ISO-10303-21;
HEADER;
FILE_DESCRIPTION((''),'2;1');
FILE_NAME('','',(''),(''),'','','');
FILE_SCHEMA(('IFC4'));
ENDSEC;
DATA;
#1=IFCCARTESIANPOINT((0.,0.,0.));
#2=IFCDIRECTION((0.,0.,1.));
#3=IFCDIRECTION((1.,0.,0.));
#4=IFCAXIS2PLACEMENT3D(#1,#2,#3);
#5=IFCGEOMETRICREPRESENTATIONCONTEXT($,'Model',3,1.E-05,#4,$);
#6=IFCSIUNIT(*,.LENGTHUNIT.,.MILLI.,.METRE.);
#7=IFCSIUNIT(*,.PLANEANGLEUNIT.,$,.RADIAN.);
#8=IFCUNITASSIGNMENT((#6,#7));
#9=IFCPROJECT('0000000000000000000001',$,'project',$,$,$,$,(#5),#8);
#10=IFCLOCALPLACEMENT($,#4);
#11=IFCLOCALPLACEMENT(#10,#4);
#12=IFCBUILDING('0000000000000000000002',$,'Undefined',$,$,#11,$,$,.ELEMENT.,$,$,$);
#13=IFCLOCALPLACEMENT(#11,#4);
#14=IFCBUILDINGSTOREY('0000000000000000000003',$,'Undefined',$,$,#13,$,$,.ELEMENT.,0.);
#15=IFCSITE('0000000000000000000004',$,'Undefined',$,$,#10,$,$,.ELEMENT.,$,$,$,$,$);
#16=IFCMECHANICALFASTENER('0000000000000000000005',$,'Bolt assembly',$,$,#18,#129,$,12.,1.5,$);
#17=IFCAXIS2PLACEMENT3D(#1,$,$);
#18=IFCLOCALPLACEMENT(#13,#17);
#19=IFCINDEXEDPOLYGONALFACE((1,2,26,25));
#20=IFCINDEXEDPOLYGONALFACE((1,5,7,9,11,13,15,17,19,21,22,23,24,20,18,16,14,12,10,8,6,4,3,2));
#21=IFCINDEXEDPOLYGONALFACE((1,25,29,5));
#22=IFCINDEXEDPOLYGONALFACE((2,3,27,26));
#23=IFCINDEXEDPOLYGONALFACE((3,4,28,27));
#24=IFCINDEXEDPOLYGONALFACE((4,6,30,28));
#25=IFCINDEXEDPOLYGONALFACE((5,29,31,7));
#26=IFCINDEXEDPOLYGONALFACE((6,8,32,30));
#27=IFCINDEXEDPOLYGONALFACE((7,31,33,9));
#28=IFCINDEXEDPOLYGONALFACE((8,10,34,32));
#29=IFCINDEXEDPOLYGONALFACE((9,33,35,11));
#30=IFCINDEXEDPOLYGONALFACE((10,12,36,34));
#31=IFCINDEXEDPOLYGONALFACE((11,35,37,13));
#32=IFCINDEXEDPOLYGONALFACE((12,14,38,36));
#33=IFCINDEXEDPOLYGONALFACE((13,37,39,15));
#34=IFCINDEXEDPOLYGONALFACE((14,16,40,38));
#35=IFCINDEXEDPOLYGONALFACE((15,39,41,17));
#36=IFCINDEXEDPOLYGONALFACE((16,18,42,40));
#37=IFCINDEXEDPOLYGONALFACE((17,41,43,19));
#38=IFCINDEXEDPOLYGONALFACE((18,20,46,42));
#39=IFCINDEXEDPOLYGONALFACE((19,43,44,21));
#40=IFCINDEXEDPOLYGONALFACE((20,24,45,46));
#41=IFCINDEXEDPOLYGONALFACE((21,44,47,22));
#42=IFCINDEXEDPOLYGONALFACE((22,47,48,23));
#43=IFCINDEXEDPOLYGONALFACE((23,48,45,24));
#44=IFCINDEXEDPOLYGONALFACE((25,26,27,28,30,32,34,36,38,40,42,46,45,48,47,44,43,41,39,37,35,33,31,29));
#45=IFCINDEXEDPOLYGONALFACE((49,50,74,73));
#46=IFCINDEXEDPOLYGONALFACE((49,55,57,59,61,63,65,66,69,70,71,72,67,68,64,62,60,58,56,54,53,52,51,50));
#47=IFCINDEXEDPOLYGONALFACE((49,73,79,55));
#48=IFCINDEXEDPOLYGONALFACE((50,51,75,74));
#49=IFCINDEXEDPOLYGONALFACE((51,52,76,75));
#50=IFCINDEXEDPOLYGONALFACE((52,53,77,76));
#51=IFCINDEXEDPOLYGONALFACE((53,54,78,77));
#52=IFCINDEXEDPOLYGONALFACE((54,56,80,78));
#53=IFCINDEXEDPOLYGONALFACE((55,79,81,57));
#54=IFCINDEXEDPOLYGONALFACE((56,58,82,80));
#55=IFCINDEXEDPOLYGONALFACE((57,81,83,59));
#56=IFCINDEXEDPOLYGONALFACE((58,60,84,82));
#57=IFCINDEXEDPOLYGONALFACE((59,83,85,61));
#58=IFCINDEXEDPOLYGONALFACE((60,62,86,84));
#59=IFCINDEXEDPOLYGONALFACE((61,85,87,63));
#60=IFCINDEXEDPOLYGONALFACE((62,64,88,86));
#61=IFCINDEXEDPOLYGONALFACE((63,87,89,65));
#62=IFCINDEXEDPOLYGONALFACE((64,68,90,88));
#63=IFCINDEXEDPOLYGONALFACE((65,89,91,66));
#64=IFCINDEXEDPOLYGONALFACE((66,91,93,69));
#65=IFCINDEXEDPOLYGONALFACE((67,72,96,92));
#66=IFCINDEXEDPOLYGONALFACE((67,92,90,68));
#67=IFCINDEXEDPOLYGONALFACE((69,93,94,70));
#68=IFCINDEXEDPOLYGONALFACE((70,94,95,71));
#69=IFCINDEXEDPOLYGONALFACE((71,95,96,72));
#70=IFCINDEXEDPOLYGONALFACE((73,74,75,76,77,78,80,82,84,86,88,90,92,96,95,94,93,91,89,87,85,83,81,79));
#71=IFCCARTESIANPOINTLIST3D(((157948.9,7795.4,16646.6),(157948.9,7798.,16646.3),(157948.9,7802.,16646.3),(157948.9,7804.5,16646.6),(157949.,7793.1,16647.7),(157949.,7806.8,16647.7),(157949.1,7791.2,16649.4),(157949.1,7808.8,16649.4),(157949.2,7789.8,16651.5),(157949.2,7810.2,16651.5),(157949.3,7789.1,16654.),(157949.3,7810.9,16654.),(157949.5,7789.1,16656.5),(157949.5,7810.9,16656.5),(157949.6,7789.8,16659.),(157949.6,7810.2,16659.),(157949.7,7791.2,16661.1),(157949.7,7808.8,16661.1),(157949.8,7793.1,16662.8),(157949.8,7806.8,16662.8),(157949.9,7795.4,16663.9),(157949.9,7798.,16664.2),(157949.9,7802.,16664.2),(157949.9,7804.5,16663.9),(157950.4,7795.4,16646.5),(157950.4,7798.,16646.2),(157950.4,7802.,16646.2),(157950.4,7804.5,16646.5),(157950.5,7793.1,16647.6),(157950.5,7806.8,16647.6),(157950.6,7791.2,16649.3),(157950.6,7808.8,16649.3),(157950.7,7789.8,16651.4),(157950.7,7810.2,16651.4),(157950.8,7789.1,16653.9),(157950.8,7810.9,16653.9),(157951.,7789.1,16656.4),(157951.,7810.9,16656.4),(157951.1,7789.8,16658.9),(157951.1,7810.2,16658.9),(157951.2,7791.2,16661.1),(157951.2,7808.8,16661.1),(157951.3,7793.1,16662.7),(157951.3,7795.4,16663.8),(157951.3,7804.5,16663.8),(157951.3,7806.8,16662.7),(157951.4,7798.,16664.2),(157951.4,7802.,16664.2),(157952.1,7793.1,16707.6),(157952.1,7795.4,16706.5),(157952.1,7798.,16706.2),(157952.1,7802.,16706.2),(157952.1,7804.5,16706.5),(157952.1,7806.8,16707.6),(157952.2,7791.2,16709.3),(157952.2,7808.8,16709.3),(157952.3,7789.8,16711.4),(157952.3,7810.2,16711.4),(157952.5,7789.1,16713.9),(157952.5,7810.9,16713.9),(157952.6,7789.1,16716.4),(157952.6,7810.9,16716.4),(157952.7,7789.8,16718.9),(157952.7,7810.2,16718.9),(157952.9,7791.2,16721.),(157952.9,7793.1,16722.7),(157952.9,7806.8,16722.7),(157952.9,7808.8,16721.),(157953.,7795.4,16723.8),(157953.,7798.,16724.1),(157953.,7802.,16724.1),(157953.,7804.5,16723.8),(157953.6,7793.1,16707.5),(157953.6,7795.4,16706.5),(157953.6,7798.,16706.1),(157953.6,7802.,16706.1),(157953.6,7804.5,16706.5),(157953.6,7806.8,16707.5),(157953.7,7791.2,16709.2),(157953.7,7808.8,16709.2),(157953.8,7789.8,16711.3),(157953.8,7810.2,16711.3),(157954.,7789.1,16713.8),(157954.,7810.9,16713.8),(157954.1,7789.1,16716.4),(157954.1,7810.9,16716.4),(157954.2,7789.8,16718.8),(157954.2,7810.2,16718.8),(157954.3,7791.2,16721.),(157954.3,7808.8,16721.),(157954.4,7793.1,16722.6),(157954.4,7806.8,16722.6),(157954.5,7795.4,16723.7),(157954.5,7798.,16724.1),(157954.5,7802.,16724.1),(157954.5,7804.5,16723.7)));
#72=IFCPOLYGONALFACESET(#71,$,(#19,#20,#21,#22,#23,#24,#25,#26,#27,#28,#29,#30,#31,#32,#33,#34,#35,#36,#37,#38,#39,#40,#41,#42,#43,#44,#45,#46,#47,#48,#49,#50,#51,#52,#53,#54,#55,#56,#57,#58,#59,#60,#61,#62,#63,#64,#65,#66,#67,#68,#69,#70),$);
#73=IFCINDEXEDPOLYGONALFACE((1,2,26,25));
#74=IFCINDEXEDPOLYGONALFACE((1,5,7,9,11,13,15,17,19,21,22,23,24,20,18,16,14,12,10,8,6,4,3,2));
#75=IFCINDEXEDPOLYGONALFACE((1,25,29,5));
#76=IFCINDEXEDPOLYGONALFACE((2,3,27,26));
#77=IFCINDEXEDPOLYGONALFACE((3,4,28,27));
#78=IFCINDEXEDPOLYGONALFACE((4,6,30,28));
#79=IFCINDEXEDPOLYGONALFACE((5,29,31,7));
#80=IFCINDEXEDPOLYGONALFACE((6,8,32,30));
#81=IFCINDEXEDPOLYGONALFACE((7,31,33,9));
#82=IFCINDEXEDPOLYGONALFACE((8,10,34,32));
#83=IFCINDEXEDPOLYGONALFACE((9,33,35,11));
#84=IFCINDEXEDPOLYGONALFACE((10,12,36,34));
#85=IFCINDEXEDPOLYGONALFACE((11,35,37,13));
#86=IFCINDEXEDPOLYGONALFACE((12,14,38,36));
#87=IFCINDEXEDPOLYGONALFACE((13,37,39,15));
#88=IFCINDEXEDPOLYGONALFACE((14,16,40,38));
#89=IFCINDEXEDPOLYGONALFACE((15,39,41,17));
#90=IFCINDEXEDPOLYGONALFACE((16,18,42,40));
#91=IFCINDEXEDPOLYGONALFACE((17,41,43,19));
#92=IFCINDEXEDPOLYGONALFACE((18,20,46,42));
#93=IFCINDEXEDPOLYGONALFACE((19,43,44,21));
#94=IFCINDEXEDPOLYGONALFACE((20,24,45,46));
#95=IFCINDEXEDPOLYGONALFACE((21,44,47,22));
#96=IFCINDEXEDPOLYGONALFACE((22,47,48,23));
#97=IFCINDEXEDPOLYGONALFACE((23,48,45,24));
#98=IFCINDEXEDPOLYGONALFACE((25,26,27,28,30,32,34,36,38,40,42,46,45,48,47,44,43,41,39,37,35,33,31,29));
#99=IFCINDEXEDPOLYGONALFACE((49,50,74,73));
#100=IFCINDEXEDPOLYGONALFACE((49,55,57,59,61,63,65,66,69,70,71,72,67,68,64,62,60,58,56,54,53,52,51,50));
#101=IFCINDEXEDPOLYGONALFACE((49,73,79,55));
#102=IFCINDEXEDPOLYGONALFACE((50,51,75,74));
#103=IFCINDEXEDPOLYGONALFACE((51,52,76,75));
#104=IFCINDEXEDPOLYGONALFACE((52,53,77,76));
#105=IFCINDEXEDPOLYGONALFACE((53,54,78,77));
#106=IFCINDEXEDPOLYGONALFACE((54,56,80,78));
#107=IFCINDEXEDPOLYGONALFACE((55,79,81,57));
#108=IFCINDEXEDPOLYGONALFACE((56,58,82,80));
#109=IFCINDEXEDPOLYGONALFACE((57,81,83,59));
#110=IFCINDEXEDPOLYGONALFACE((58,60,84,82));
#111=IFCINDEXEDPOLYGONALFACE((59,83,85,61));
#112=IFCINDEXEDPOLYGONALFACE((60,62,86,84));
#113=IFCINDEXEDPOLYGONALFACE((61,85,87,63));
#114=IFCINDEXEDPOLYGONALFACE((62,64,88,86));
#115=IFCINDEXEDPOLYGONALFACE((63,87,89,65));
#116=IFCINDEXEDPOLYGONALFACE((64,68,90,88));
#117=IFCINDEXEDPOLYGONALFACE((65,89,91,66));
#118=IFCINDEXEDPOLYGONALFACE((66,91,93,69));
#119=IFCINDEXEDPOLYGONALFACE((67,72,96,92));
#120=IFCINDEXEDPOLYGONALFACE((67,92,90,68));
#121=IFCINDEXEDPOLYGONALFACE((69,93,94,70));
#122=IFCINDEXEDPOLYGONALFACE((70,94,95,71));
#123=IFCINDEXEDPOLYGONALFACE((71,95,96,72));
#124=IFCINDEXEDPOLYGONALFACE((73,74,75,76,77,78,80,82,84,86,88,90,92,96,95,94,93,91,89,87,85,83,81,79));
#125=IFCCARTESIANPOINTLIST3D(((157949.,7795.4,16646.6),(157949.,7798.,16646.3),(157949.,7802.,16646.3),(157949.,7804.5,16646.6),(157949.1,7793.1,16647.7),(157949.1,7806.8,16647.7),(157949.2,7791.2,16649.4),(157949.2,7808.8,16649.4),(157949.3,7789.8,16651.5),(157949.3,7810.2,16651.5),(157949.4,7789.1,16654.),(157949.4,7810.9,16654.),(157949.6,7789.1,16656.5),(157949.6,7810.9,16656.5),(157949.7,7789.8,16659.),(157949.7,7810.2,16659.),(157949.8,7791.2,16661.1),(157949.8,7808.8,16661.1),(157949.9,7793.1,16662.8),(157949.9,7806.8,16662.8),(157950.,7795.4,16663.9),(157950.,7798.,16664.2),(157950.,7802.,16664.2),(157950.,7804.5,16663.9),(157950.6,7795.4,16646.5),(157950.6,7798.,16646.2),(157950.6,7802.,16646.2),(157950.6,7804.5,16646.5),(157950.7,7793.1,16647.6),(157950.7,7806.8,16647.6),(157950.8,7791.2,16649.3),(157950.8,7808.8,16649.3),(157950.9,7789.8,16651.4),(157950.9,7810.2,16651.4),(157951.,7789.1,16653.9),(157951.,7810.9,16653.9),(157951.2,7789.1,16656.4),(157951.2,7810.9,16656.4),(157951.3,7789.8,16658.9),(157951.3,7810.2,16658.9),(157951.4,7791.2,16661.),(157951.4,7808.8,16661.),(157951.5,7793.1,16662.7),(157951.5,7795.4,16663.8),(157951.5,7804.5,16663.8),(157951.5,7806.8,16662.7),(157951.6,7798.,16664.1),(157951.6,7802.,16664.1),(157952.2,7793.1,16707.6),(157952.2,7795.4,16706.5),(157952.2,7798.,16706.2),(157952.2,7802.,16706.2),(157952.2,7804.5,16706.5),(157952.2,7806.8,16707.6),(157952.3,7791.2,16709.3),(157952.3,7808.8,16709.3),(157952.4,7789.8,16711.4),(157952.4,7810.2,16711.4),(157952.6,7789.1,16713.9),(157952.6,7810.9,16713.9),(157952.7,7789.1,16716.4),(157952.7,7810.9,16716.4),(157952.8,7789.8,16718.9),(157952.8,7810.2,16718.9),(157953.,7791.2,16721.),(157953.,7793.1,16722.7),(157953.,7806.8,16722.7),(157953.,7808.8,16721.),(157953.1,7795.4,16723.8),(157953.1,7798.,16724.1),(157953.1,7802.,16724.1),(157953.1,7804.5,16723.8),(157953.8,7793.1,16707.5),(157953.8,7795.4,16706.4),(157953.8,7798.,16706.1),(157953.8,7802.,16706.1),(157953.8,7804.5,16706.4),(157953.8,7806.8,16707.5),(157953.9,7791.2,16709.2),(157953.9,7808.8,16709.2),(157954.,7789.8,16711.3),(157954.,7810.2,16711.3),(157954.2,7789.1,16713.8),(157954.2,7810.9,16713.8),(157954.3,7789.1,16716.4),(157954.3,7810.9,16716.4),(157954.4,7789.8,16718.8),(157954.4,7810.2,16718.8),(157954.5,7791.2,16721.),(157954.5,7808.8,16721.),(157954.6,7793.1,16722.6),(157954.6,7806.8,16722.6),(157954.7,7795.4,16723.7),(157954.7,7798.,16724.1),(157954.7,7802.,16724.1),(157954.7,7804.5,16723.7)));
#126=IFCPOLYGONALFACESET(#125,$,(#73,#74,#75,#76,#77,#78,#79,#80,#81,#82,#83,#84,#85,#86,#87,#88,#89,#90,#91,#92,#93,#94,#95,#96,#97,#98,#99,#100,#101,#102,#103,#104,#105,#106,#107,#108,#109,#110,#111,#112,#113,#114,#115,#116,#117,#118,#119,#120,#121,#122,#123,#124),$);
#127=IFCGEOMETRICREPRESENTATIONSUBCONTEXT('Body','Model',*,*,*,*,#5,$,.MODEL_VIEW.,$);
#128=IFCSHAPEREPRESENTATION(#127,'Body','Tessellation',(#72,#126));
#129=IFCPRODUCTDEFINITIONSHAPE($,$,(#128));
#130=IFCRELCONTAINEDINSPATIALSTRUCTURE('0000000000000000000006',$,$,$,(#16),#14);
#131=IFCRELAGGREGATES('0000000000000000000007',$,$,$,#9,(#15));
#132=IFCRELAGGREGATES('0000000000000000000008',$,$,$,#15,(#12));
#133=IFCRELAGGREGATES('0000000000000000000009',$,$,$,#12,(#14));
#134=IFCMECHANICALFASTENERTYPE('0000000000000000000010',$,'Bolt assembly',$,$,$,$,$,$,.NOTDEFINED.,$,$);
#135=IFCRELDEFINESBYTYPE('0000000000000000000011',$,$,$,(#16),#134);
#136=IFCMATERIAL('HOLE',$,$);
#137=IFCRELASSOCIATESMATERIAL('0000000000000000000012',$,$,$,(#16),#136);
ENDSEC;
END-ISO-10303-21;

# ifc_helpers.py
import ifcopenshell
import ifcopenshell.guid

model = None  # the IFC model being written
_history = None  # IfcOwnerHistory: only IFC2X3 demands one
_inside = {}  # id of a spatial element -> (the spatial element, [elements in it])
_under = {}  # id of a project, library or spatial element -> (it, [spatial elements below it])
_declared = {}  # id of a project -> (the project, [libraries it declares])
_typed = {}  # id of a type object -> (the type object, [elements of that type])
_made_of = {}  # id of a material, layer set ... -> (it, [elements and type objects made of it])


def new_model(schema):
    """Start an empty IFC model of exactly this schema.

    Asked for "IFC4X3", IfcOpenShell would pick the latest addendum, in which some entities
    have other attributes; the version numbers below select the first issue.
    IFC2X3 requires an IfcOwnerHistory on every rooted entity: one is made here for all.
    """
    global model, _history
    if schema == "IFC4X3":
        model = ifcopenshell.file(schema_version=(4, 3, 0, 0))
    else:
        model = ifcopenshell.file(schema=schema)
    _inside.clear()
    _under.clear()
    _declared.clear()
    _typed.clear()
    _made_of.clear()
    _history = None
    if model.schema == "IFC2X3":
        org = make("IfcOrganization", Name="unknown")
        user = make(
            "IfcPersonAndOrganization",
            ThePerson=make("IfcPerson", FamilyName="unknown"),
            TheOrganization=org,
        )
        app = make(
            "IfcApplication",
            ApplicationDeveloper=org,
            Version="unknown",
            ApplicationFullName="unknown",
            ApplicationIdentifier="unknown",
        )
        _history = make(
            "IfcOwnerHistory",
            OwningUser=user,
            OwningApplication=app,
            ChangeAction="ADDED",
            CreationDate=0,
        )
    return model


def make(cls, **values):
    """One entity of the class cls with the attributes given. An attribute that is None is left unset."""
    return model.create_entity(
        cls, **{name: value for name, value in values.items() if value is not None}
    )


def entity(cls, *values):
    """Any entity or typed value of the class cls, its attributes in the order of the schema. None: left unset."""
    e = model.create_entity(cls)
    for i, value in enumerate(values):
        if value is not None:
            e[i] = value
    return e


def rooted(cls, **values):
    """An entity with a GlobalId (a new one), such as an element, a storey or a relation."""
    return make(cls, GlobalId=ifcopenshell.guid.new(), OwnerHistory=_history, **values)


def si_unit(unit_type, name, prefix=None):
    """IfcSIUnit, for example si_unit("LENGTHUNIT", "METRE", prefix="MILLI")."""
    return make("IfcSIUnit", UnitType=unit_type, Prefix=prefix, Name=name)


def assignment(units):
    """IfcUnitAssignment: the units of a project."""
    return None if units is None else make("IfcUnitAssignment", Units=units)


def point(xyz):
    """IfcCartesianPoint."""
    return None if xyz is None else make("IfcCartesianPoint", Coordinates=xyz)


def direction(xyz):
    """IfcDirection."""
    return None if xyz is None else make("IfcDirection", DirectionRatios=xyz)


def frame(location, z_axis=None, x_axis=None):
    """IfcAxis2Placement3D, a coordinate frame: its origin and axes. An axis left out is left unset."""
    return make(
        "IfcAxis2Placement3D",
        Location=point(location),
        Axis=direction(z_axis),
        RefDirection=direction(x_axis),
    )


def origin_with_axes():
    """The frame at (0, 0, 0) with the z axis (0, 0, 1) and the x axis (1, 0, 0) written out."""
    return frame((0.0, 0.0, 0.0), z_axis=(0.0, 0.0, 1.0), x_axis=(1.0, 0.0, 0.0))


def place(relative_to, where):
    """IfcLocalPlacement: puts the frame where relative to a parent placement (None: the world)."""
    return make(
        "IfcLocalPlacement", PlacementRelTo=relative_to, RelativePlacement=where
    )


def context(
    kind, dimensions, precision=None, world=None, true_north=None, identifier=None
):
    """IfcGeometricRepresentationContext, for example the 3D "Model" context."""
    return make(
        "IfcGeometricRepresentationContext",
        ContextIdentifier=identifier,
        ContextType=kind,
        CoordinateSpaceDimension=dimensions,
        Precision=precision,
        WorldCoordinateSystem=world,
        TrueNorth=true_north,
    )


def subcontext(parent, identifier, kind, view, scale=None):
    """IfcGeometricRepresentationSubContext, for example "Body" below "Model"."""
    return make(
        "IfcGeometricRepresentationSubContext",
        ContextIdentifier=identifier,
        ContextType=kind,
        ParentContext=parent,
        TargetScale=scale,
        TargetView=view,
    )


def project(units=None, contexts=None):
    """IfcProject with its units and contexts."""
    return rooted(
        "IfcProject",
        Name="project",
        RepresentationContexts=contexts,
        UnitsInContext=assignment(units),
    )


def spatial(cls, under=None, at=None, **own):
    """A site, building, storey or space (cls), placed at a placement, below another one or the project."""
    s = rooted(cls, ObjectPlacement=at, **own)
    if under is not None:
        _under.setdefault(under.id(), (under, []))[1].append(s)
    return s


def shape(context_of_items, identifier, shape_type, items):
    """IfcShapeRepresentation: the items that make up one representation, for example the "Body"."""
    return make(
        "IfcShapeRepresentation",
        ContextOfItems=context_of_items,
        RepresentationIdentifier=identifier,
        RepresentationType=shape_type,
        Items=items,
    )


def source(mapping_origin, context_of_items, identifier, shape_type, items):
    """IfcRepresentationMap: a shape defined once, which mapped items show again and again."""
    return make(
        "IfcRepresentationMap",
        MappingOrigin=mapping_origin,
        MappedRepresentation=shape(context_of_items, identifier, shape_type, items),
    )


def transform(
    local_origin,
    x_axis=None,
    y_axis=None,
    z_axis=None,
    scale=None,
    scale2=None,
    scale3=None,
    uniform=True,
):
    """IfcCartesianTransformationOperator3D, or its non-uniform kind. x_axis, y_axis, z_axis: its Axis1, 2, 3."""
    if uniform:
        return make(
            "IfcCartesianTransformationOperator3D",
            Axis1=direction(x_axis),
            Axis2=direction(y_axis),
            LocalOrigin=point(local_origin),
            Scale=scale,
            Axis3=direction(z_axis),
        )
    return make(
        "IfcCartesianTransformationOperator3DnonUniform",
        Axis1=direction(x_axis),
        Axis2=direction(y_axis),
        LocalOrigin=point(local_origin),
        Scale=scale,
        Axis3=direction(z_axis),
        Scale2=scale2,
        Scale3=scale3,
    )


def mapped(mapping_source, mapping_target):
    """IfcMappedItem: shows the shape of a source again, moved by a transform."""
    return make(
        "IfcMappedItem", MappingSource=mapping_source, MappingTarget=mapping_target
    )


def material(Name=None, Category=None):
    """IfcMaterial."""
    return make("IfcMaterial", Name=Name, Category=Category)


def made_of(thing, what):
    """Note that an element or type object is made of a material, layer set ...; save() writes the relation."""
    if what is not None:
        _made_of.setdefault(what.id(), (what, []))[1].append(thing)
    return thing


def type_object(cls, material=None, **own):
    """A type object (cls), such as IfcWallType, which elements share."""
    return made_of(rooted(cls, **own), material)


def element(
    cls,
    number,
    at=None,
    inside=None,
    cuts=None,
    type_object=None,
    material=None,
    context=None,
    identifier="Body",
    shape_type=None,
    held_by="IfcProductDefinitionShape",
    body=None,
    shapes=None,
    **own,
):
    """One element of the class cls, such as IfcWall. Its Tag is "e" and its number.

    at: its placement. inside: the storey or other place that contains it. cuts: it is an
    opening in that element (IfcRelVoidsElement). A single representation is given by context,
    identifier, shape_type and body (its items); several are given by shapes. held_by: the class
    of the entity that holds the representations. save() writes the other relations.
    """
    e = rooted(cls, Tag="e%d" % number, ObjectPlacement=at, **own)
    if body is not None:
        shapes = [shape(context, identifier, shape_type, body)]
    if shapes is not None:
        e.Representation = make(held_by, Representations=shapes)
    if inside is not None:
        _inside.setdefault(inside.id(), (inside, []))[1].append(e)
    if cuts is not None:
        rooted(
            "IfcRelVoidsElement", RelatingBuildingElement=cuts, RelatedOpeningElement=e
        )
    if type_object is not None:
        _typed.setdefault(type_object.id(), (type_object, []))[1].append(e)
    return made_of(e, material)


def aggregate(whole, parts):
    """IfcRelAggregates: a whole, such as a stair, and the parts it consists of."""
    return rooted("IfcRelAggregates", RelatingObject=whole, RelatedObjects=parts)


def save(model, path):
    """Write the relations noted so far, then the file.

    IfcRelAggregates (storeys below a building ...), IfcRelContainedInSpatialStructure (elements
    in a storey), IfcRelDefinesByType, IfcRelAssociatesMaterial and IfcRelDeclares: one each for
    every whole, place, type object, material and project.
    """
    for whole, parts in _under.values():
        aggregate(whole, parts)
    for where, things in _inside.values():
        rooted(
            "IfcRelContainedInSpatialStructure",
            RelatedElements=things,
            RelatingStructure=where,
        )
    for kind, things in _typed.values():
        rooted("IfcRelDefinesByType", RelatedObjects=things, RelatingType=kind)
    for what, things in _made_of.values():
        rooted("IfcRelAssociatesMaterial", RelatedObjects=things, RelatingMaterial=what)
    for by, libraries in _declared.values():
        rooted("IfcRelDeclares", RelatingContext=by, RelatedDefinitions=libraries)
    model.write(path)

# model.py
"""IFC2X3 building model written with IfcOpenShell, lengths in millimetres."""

from ifc_helpers import new_model, entity, si_unit, frame, origin_with_axes, place, context, subcontext, project, spatial, source, transform, mapped, material, type_object, element, save


model = new_model("IFC2X3")

# Units and contexts
model_context = context("Model", 3, precision=1e-05, world=origin_with_axes())
body_context = subcontext(model_context, "Body", "Model", "MODEL_VIEW")
ifc_project = project(units=[si_unit("LENGTHUNIT", "METRE", prefix="MILLI"), si_unit("PLANEANGLEUNIT", "RADIAN")], contexts=[model_context])

# Site, building, storey
site_placement = place(None, origin_with_axes())
site = spatial("IfcSite", under=ifc_project, at=site_placement, Name="Undefined", CompositionType="ELEMENT")
building_placement = place(site_placement, origin_with_axes())
building = spatial("IfcBuilding", under=site, at=building_placement, Name="Undefined", CompositionType="ELEMENT")
storey_placement = place(building_placement, origin_with_axes())
storey = spatial("IfcBuildingStorey", under=building, at=storey_placement, Name="Undefined", CompositionType="ELEMENT", Elevation=0.0)

# Mechanical fastener
ifc_material_1 = material(Name="HOLE")
mechanical_fastener_type = type_object("IfcMechanicalFastenerType", Name="Bolt assembly")
shared_circle_1 = entity("IfcCircle", entity("IfcAxis2Placement2D", entity("IfcCartesianPoint", [0.0, -2.0]), entity("IfcDirection", [1.0, 0.0])), 9.0)
shared_circle_2 = entity("IfcCircle", entity("IfcAxis2Placement2D", entity("IfcCartesianPoint", [0.0, 2.0]), entity("IfcDirection", [-1.0, 0.0])), 9.0)
shared_composite_curve = entity("IfcCompositeCurve", [entity("IfcCompositeCurveSegment", "CONTINUOUS", True, entity("IfcPolyline", [entity("IfcCartesianPoint", [9.0, 2.0]), entity("IfcCartesianPoint", [9.0, -2.0])])), entity("IfcCompositeCurveSegment", "CONTINUOUS", True, entity("IfcTrimmedCurve", shared_circle_1, [entity("IfcParameterValue", 0.0)], [entity("IfcParameterValue", 3.141593)], False, "PARAMETER")), entity("IfcCompositeCurveSegment", "CONTINUOUS", True, entity("IfcPolyline", [entity("IfcCartesianPoint", [-9.0, -2.0]), entity("IfcCartesianPoint", [-9.0, 2.0])])), entity("IfcCompositeCurveSegment", "DISCONTINUOUS", True, entity("IfcTrimmedCurve", shared_circle_2, [entity("IfcParameterValue", 0.0)], [entity("IfcParameterValue", 3.141593)], False, "PARAMETER"))], False)
shared_shape_1 = source(origin_with_axes(), body_context, "Body", "SweptSolid", [
    entity("IfcExtrudedAreaSolid", entity("IfcArbitraryClosedProfileDef", "AREA", None, shared_composite_curve), entity("IfcAxis2Placement3D", entity("IfcCartesianPoint", [0.0, 0.1, 0.0]), entity("IfcDirection", [0.0, 1.0, 0.0]), entity("IfcDirection", [1.0, 0.0, 0.0])), entity("IfcDirection", [0.0, 0.0, 1.0]), 1.5),
    entity("IfcExtrudedAreaSolid", entity("IfcArbitraryClosedProfileDef", "AREA", None, shared_composite_curve), entity("IfcAxis2Placement3D", entity("IfcCartesianPoint", [0.0, -0.1, 0.0]), entity("IfcDirection", [0.0, 1.0, 0.0]), entity("IfcDirection", [1.0, 0.0, 0.0])), entity("IfcDirection", [0.0, 0.0, 1.0]), 1.6),
])
mechanical_fastener_1_placement = place(storey_placement, frame((157954.1, 7800.0, 16715.1), z_axis=(0.0, 1.0, 0.0), x_axis=(-0.052392, 0.0, -0.998627)))
element("IfcMechanicalFastener", 1, at=mechanical_fastener_1_placement, inside=storey, type_object=mechanical_fastener_type, material=ifc_material_1, Name="Bolt assembly", NominalDiameter=12.0, NominalLength=1.5, context=body_context, shape_type="MappedRepresentation", body=[
    mapped(shared_shape_1, transform((0.0, 0.0, 0.0))),
    mapped(shared_shape_1, transform((60.0, 0.0, 0.0))),
])

save(model, "model.ifc")
